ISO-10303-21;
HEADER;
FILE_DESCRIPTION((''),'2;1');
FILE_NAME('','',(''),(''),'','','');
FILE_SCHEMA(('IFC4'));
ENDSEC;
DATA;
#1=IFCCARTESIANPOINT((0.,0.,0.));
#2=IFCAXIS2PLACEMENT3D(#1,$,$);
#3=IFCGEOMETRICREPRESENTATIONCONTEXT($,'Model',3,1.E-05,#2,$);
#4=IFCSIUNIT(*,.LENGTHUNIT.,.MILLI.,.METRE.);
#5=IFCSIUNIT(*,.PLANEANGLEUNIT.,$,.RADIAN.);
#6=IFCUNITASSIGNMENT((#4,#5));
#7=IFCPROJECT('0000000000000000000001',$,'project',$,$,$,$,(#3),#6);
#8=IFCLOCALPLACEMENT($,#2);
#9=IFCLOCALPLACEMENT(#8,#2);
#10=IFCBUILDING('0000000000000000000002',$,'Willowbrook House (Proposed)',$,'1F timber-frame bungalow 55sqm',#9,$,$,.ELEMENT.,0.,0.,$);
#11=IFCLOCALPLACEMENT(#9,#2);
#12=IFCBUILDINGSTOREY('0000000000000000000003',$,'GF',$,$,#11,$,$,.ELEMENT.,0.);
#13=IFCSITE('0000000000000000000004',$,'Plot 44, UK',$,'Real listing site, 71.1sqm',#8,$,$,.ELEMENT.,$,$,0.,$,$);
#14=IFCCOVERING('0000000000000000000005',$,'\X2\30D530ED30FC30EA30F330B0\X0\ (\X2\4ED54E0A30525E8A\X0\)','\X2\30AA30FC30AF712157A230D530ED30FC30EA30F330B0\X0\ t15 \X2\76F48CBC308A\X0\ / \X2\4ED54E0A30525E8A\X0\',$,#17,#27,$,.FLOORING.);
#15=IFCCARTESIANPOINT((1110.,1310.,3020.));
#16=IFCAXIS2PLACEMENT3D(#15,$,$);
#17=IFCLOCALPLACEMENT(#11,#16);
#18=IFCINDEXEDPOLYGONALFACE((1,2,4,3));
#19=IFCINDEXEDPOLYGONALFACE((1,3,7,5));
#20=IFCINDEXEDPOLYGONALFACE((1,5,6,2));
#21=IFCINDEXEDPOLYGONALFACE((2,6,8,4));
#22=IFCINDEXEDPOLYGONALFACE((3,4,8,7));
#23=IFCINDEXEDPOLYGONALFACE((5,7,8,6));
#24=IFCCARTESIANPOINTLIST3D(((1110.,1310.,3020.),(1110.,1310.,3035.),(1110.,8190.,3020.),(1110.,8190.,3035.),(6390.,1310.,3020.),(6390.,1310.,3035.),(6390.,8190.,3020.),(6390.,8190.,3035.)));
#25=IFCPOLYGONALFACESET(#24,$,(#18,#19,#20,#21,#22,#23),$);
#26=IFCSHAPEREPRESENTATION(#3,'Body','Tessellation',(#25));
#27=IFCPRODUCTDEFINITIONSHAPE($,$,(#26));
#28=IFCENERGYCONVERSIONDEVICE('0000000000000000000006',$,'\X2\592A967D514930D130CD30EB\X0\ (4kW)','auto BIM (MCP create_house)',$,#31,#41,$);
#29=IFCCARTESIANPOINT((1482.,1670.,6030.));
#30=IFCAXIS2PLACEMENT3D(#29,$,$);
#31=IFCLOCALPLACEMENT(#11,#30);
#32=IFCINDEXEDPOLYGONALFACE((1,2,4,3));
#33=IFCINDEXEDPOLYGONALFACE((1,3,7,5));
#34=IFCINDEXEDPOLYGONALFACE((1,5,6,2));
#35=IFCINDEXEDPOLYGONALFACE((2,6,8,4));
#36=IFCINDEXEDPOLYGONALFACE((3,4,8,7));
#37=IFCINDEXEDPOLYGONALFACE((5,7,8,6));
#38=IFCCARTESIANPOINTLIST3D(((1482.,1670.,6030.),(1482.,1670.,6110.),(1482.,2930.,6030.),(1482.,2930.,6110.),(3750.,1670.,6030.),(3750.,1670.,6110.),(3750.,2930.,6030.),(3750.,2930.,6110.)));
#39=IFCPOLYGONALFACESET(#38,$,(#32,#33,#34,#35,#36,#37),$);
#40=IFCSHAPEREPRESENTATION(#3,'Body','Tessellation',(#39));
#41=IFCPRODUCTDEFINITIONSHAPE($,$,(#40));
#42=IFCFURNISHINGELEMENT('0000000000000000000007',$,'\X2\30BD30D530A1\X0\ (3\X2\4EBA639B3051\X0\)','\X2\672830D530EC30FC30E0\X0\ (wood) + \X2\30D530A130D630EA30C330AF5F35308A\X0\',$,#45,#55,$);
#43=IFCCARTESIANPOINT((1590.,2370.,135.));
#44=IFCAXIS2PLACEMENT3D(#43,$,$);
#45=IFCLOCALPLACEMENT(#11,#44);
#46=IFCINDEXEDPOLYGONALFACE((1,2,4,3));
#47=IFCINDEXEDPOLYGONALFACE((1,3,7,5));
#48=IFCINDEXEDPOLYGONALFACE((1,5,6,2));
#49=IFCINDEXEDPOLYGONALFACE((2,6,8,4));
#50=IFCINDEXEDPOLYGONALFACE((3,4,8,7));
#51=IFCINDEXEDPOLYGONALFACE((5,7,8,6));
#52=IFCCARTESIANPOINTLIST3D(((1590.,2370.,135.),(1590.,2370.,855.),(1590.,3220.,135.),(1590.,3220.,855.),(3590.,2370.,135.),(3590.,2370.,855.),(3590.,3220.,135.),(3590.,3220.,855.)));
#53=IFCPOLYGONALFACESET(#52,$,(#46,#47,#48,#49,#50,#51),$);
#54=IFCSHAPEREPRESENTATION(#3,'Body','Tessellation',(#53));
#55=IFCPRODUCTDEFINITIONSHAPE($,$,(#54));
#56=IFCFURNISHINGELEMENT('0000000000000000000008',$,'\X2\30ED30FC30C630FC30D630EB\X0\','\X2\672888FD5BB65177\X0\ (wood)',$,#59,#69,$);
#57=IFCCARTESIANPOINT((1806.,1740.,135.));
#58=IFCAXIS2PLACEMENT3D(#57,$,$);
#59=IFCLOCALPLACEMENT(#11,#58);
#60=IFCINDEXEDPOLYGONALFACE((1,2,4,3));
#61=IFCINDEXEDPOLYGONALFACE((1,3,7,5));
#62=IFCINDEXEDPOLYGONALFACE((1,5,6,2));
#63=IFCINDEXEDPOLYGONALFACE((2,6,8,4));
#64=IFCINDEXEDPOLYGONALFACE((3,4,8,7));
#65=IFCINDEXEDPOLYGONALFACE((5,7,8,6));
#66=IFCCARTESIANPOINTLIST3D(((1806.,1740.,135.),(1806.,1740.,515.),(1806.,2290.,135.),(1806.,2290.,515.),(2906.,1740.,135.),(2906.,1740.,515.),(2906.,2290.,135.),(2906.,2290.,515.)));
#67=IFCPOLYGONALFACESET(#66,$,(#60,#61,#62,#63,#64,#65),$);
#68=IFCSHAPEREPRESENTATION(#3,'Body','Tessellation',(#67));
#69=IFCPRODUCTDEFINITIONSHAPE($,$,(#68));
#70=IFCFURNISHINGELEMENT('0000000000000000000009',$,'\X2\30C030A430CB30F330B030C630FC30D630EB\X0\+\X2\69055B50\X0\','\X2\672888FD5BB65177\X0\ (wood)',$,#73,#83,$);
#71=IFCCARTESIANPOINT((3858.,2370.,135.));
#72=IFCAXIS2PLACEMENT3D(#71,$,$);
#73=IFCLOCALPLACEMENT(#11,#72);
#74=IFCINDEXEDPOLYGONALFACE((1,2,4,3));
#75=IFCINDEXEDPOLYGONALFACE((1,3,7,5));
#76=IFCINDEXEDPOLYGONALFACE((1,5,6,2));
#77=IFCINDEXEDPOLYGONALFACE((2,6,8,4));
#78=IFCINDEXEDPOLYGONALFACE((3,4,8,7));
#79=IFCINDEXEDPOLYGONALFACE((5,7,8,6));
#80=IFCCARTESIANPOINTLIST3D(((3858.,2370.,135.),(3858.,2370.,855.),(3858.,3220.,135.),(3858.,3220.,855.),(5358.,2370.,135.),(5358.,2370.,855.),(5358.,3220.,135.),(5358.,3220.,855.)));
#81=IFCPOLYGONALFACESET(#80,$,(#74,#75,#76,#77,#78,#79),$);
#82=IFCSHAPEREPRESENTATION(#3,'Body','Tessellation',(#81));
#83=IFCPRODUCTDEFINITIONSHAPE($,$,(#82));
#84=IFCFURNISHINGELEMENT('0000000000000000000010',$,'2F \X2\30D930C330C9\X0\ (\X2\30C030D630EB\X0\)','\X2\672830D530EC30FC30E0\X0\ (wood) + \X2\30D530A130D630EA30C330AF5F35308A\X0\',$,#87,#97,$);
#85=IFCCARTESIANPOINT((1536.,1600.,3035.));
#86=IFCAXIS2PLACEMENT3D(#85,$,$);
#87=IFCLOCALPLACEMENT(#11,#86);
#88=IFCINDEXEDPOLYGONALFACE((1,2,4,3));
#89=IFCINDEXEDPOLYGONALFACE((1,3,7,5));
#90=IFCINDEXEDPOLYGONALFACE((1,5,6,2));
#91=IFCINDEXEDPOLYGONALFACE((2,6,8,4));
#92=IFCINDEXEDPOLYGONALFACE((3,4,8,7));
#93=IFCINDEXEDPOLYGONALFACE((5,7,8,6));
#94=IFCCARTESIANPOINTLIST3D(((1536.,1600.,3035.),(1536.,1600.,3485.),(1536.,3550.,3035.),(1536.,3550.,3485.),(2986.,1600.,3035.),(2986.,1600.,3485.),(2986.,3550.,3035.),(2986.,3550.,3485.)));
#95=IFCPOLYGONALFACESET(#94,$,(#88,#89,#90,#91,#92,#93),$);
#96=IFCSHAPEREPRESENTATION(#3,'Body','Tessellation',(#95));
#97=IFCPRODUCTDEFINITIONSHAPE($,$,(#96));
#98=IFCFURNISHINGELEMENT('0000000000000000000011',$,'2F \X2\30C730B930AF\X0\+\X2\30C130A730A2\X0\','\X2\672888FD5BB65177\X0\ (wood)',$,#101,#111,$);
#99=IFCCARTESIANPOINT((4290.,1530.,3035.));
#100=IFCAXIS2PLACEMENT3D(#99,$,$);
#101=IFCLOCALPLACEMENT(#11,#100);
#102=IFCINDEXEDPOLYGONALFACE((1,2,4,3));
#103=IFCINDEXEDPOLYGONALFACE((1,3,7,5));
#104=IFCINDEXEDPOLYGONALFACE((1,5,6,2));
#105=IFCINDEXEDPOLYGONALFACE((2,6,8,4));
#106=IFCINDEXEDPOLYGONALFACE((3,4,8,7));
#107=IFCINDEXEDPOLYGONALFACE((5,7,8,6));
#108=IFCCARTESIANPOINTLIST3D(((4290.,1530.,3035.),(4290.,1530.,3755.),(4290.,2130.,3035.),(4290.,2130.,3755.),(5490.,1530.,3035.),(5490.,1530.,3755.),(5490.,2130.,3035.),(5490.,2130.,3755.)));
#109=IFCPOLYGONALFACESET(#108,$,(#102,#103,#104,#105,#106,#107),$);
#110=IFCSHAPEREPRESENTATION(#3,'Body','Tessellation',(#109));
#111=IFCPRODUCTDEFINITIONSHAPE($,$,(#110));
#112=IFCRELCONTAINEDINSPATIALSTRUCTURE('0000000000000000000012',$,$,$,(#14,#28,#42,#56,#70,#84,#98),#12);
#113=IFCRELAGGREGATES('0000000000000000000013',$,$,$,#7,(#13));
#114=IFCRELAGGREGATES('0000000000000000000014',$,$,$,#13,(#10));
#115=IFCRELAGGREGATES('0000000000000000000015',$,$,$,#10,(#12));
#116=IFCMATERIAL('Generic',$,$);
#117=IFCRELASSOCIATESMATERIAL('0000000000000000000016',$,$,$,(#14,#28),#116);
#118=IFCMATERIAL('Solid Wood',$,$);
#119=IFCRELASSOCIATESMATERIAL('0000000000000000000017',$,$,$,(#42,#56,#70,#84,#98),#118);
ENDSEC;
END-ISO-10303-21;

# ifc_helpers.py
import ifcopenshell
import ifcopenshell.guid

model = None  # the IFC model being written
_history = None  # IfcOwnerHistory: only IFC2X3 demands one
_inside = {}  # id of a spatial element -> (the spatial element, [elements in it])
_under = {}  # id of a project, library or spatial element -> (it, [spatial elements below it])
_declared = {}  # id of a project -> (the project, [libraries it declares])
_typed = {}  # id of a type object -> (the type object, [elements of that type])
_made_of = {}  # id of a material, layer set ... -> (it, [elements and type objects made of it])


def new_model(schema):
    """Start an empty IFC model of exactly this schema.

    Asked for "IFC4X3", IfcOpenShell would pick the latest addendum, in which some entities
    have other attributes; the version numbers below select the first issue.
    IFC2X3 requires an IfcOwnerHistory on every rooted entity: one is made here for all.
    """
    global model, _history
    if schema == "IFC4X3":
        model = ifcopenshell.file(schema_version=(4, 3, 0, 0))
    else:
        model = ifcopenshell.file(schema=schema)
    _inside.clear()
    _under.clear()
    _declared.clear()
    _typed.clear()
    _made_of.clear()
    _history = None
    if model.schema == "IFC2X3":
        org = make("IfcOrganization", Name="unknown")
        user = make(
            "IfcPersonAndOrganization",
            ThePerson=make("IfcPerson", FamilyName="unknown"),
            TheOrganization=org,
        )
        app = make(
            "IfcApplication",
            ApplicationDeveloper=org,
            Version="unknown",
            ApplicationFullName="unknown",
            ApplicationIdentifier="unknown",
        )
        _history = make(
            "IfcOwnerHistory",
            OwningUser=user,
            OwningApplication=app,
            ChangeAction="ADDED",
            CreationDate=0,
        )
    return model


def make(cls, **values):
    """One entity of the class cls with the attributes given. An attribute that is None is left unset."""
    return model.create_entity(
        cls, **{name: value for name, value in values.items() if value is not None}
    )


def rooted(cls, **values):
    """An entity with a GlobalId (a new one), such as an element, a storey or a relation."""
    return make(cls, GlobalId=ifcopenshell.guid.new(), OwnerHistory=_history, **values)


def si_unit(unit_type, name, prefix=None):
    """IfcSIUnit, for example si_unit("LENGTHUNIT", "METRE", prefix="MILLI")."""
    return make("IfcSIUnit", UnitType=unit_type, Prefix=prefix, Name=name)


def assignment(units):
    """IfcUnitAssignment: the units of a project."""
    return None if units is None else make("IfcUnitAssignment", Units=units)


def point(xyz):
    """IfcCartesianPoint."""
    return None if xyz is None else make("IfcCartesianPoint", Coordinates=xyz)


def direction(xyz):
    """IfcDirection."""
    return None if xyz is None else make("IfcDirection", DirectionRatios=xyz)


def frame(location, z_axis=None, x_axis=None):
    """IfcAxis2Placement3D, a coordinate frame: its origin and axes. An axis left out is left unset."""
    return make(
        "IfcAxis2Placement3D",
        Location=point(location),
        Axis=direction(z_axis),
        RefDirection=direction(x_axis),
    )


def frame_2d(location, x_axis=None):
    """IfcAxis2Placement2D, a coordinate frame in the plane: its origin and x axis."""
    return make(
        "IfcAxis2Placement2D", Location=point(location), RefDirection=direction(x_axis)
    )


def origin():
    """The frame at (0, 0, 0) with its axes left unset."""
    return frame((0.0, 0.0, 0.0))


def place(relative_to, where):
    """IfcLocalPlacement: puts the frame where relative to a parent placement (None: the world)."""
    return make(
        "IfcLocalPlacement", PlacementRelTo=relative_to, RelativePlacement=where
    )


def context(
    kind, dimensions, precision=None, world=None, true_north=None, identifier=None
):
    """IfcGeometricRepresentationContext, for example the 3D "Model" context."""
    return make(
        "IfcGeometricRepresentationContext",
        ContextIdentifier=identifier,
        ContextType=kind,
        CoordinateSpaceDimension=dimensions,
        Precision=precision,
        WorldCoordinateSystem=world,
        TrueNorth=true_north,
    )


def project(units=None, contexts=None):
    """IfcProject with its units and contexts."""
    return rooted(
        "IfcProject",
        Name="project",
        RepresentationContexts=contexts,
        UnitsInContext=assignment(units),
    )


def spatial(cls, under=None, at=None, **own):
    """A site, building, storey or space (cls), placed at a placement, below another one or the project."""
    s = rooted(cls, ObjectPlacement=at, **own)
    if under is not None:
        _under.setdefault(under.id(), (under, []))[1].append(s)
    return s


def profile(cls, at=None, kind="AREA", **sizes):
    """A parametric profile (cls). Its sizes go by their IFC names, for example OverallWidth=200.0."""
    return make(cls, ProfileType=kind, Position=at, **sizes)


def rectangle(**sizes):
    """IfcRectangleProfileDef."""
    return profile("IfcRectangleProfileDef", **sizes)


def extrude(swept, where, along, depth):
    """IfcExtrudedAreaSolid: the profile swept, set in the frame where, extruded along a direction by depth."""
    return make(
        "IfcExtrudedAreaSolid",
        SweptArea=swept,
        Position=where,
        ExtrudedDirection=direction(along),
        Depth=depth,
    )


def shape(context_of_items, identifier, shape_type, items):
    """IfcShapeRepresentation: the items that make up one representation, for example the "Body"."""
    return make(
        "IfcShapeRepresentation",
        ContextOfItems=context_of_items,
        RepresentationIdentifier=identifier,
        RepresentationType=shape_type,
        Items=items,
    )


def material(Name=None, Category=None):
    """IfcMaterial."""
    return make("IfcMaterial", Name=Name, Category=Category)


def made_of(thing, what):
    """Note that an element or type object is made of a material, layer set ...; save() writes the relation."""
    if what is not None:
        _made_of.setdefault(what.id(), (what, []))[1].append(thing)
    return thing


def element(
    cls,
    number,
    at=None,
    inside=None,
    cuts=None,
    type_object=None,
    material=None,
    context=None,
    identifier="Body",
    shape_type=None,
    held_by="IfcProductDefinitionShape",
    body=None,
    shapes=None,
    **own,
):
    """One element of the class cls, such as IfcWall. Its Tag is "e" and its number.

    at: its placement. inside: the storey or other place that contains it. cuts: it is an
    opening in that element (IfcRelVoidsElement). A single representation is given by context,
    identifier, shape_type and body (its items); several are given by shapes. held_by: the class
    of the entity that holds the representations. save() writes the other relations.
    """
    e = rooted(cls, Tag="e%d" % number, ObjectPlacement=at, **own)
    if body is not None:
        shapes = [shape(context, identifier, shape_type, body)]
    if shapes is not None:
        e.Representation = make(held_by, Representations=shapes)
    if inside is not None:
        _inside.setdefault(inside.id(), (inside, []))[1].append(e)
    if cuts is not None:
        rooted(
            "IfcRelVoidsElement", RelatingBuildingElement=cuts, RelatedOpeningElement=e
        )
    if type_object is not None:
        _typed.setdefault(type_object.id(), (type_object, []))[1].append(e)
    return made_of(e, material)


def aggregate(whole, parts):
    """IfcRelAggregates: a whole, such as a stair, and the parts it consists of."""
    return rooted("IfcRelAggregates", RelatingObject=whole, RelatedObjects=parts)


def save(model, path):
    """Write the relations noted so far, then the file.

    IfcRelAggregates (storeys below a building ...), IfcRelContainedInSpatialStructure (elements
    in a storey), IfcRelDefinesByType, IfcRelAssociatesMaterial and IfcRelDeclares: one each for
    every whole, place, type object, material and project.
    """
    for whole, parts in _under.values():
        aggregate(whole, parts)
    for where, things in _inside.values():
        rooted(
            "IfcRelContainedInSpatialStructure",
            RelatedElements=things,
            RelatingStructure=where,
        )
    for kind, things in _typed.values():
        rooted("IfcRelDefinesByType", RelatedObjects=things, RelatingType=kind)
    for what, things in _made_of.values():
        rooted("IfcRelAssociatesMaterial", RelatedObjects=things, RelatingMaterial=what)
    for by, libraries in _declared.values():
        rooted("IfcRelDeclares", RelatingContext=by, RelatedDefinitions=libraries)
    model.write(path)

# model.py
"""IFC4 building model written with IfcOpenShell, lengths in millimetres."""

from ifc_helpers import new_model, si_unit, frame, frame_2d, origin, place, context, project, spatial, rectangle, extrude, material, element, save


model = new_model("IFC4")

# Units and contexts
model_context = context("Model", 3, precision=1e-05, world=origin())
ifc_project = project(units=[si_unit("LENGTHUNIT", "METRE", prefix="MILLI"), si_unit("PLANEANGLEUNIT", "RADIAN")], contexts=[model_context])

# Site, building, storey
site_placement = place(None, origin())
site = spatial("IfcSite", under=ifc_project, at=site_placement, Name="Plot 44, UK", ObjectType="Real listing site, 71.1sqm", CompositionType="ELEMENT", RefElevation=0.0)
building_placement = place(site_placement, origin())
building = spatial("IfcBuilding", under=site, at=building_placement, Name="Willowbrook House (Proposed)", ObjectType="1F timber-frame bungalow 55sqm", CompositionType="ELEMENT", ElevationOfRefHeight=0.0, ElevationOfTerrain=0.0)
storey_placement = place(building_placement, origin())
storey = spatial("IfcBuildingStorey", under=building, at=storey_placement, Name="GF", CompositionType="ELEMENT", Elevation=0.0)

# Shared definitions
ifc_material_1 = material(Name="Solid Wood")

# Shared definitions
ifc_material_2 = material(Name="Generic")

# Covering
covering_placement = place(storey_placement, frame((1110.0, 1310.0, 3020.0)))
element("IfcCovering", 1, at=covering_placement, inside=storey, material=ifc_material_2, Name="フローリング (仕上げ床)", Description="オーク無垢フローリング t15 直貼り / 仕上げ床", PredefinedType="FLOORING", context=model_context, shape_type="SweptSolid", body=[
    extrude(rectangle(XDim=5280.0, YDim=6880.0, at=frame_2d((2640.0, 3440.0))), frame((1110.0, 1310.0, 3020.0)), (0.0, 0.0, 1.0), 15.0),
])

# Energy conversion device
energy_conversion_device_placement = place(storey_placement, frame((1482.0, 1670.0, 6030.0)))
element("IfcEnergyConversionDevice", 2, at=energy_conversion_device_placement, inside=storey, material=ifc_material_2, Name="太陽光パネル (4kW)", Description="auto BIM (MCP create_house)", context=model_context, shape_type="SweptSolid", body=[
    extrude(rectangle(XDim=2268.0, YDim=1260.0, at=frame_2d((1134.0, 630.0))), frame((1482.0, 1670.0, 6030.0)), (0.0, 0.0, 1.0), 80.0),
])

# Furnishing elements
furnishing_1_placement = place(storey_placement, frame((1590.0, 2370.0, 135.0)))
element("IfcFurnishingElement", 3, at=furnishing_1_placement, inside=storey, material=ifc_material_1, Name="ソファ (3人掛け)", Description="木フレーム (wood) + ファブリック張り", context=model_context, shape_type="SweptSolid", body=[
    extrude(rectangle(XDim=2000.0, YDim=850.0, at=frame_2d((1000.0, 425.0))), frame((1590.0, 2370.0, 135.0)), (0.0, 0.0, 1.0), 720.0),
])
furnishing_2_placement = place(storey_placement, frame((1806.0, 1740.0, 135.0)))
element("IfcFurnishingElement", 4, at=furnishing_2_placement, inside=storey, material=ifc_material_1, Name="ローテーブル", Description="木製家具 (wood)", context=model_context, shape_type="SweptSolid", body=[
    extrude(rectangle(XDim=1100.0, YDim=550.0, at=frame_2d((550.0, 275.0))), frame((1806.0, 1740.0, 135.0)), (0.0, 0.0, 1.0), 380.0),
])
furnishing_3_placement = place(storey_placement, frame((3858.0, 2370.0, 135.0)))
element("IfcFurnishingElement", 5, at=furnishing_3_placement, inside=storey, material=ifc_material_1, Name="ダイニングテーブル+椅子", Description="木製家具 (wood)", context=model_context, shape_type="SweptSolid", body=[
    extrude(rectangle(XDim=1500.0, YDim=850.0, at=frame_2d((750.0, 425.0))), frame((3858.0, 2370.0, 135.0)), (0.0, 0.0, 1.0), 720.0),
])
furnishing_4_placement = place(storey_placement, frame((1536.0, 1600.0, 3035.0)))
element("IfcFurnishingElement", 6, at=furnishing_4_placement, inside=storey, material=ifc_material_1, Name="2F ベッド (ダブル)", Description="木フレーム (wood) + ファブリック張り", context=model_context, shape_type="SweptSolid", body=[
    extrude(rectangle(XDim=1450.0, YDim=1950.0, at=frame_2d((725.0, 975.0))), frame((1536.0, 1600.0, 3035.0)), (0.0, 0.0, 1.0), 450.0),
])
furnishing_5_placement = place(storey_placement, frame((4290.0, 1530.0, 3035.0)))
element("IfcFurnishingElement", 7, at=furnishing_5_placement, inside=storey, material=ifc_material_1, Name="2F デスク+チェア", Description="木製家具 (wood)", context=model_context, shape_type="SweptSolid", body=[
    extrude(rectangle(XDim=1200.0, YDim=600.0, at=frame_2d((600.0, 300.0))), frame((4290.0, 1530.0, 3035.0)), (0.0, 0.0, 1.0), 720.0),
])

save(model, "model.ifc")
